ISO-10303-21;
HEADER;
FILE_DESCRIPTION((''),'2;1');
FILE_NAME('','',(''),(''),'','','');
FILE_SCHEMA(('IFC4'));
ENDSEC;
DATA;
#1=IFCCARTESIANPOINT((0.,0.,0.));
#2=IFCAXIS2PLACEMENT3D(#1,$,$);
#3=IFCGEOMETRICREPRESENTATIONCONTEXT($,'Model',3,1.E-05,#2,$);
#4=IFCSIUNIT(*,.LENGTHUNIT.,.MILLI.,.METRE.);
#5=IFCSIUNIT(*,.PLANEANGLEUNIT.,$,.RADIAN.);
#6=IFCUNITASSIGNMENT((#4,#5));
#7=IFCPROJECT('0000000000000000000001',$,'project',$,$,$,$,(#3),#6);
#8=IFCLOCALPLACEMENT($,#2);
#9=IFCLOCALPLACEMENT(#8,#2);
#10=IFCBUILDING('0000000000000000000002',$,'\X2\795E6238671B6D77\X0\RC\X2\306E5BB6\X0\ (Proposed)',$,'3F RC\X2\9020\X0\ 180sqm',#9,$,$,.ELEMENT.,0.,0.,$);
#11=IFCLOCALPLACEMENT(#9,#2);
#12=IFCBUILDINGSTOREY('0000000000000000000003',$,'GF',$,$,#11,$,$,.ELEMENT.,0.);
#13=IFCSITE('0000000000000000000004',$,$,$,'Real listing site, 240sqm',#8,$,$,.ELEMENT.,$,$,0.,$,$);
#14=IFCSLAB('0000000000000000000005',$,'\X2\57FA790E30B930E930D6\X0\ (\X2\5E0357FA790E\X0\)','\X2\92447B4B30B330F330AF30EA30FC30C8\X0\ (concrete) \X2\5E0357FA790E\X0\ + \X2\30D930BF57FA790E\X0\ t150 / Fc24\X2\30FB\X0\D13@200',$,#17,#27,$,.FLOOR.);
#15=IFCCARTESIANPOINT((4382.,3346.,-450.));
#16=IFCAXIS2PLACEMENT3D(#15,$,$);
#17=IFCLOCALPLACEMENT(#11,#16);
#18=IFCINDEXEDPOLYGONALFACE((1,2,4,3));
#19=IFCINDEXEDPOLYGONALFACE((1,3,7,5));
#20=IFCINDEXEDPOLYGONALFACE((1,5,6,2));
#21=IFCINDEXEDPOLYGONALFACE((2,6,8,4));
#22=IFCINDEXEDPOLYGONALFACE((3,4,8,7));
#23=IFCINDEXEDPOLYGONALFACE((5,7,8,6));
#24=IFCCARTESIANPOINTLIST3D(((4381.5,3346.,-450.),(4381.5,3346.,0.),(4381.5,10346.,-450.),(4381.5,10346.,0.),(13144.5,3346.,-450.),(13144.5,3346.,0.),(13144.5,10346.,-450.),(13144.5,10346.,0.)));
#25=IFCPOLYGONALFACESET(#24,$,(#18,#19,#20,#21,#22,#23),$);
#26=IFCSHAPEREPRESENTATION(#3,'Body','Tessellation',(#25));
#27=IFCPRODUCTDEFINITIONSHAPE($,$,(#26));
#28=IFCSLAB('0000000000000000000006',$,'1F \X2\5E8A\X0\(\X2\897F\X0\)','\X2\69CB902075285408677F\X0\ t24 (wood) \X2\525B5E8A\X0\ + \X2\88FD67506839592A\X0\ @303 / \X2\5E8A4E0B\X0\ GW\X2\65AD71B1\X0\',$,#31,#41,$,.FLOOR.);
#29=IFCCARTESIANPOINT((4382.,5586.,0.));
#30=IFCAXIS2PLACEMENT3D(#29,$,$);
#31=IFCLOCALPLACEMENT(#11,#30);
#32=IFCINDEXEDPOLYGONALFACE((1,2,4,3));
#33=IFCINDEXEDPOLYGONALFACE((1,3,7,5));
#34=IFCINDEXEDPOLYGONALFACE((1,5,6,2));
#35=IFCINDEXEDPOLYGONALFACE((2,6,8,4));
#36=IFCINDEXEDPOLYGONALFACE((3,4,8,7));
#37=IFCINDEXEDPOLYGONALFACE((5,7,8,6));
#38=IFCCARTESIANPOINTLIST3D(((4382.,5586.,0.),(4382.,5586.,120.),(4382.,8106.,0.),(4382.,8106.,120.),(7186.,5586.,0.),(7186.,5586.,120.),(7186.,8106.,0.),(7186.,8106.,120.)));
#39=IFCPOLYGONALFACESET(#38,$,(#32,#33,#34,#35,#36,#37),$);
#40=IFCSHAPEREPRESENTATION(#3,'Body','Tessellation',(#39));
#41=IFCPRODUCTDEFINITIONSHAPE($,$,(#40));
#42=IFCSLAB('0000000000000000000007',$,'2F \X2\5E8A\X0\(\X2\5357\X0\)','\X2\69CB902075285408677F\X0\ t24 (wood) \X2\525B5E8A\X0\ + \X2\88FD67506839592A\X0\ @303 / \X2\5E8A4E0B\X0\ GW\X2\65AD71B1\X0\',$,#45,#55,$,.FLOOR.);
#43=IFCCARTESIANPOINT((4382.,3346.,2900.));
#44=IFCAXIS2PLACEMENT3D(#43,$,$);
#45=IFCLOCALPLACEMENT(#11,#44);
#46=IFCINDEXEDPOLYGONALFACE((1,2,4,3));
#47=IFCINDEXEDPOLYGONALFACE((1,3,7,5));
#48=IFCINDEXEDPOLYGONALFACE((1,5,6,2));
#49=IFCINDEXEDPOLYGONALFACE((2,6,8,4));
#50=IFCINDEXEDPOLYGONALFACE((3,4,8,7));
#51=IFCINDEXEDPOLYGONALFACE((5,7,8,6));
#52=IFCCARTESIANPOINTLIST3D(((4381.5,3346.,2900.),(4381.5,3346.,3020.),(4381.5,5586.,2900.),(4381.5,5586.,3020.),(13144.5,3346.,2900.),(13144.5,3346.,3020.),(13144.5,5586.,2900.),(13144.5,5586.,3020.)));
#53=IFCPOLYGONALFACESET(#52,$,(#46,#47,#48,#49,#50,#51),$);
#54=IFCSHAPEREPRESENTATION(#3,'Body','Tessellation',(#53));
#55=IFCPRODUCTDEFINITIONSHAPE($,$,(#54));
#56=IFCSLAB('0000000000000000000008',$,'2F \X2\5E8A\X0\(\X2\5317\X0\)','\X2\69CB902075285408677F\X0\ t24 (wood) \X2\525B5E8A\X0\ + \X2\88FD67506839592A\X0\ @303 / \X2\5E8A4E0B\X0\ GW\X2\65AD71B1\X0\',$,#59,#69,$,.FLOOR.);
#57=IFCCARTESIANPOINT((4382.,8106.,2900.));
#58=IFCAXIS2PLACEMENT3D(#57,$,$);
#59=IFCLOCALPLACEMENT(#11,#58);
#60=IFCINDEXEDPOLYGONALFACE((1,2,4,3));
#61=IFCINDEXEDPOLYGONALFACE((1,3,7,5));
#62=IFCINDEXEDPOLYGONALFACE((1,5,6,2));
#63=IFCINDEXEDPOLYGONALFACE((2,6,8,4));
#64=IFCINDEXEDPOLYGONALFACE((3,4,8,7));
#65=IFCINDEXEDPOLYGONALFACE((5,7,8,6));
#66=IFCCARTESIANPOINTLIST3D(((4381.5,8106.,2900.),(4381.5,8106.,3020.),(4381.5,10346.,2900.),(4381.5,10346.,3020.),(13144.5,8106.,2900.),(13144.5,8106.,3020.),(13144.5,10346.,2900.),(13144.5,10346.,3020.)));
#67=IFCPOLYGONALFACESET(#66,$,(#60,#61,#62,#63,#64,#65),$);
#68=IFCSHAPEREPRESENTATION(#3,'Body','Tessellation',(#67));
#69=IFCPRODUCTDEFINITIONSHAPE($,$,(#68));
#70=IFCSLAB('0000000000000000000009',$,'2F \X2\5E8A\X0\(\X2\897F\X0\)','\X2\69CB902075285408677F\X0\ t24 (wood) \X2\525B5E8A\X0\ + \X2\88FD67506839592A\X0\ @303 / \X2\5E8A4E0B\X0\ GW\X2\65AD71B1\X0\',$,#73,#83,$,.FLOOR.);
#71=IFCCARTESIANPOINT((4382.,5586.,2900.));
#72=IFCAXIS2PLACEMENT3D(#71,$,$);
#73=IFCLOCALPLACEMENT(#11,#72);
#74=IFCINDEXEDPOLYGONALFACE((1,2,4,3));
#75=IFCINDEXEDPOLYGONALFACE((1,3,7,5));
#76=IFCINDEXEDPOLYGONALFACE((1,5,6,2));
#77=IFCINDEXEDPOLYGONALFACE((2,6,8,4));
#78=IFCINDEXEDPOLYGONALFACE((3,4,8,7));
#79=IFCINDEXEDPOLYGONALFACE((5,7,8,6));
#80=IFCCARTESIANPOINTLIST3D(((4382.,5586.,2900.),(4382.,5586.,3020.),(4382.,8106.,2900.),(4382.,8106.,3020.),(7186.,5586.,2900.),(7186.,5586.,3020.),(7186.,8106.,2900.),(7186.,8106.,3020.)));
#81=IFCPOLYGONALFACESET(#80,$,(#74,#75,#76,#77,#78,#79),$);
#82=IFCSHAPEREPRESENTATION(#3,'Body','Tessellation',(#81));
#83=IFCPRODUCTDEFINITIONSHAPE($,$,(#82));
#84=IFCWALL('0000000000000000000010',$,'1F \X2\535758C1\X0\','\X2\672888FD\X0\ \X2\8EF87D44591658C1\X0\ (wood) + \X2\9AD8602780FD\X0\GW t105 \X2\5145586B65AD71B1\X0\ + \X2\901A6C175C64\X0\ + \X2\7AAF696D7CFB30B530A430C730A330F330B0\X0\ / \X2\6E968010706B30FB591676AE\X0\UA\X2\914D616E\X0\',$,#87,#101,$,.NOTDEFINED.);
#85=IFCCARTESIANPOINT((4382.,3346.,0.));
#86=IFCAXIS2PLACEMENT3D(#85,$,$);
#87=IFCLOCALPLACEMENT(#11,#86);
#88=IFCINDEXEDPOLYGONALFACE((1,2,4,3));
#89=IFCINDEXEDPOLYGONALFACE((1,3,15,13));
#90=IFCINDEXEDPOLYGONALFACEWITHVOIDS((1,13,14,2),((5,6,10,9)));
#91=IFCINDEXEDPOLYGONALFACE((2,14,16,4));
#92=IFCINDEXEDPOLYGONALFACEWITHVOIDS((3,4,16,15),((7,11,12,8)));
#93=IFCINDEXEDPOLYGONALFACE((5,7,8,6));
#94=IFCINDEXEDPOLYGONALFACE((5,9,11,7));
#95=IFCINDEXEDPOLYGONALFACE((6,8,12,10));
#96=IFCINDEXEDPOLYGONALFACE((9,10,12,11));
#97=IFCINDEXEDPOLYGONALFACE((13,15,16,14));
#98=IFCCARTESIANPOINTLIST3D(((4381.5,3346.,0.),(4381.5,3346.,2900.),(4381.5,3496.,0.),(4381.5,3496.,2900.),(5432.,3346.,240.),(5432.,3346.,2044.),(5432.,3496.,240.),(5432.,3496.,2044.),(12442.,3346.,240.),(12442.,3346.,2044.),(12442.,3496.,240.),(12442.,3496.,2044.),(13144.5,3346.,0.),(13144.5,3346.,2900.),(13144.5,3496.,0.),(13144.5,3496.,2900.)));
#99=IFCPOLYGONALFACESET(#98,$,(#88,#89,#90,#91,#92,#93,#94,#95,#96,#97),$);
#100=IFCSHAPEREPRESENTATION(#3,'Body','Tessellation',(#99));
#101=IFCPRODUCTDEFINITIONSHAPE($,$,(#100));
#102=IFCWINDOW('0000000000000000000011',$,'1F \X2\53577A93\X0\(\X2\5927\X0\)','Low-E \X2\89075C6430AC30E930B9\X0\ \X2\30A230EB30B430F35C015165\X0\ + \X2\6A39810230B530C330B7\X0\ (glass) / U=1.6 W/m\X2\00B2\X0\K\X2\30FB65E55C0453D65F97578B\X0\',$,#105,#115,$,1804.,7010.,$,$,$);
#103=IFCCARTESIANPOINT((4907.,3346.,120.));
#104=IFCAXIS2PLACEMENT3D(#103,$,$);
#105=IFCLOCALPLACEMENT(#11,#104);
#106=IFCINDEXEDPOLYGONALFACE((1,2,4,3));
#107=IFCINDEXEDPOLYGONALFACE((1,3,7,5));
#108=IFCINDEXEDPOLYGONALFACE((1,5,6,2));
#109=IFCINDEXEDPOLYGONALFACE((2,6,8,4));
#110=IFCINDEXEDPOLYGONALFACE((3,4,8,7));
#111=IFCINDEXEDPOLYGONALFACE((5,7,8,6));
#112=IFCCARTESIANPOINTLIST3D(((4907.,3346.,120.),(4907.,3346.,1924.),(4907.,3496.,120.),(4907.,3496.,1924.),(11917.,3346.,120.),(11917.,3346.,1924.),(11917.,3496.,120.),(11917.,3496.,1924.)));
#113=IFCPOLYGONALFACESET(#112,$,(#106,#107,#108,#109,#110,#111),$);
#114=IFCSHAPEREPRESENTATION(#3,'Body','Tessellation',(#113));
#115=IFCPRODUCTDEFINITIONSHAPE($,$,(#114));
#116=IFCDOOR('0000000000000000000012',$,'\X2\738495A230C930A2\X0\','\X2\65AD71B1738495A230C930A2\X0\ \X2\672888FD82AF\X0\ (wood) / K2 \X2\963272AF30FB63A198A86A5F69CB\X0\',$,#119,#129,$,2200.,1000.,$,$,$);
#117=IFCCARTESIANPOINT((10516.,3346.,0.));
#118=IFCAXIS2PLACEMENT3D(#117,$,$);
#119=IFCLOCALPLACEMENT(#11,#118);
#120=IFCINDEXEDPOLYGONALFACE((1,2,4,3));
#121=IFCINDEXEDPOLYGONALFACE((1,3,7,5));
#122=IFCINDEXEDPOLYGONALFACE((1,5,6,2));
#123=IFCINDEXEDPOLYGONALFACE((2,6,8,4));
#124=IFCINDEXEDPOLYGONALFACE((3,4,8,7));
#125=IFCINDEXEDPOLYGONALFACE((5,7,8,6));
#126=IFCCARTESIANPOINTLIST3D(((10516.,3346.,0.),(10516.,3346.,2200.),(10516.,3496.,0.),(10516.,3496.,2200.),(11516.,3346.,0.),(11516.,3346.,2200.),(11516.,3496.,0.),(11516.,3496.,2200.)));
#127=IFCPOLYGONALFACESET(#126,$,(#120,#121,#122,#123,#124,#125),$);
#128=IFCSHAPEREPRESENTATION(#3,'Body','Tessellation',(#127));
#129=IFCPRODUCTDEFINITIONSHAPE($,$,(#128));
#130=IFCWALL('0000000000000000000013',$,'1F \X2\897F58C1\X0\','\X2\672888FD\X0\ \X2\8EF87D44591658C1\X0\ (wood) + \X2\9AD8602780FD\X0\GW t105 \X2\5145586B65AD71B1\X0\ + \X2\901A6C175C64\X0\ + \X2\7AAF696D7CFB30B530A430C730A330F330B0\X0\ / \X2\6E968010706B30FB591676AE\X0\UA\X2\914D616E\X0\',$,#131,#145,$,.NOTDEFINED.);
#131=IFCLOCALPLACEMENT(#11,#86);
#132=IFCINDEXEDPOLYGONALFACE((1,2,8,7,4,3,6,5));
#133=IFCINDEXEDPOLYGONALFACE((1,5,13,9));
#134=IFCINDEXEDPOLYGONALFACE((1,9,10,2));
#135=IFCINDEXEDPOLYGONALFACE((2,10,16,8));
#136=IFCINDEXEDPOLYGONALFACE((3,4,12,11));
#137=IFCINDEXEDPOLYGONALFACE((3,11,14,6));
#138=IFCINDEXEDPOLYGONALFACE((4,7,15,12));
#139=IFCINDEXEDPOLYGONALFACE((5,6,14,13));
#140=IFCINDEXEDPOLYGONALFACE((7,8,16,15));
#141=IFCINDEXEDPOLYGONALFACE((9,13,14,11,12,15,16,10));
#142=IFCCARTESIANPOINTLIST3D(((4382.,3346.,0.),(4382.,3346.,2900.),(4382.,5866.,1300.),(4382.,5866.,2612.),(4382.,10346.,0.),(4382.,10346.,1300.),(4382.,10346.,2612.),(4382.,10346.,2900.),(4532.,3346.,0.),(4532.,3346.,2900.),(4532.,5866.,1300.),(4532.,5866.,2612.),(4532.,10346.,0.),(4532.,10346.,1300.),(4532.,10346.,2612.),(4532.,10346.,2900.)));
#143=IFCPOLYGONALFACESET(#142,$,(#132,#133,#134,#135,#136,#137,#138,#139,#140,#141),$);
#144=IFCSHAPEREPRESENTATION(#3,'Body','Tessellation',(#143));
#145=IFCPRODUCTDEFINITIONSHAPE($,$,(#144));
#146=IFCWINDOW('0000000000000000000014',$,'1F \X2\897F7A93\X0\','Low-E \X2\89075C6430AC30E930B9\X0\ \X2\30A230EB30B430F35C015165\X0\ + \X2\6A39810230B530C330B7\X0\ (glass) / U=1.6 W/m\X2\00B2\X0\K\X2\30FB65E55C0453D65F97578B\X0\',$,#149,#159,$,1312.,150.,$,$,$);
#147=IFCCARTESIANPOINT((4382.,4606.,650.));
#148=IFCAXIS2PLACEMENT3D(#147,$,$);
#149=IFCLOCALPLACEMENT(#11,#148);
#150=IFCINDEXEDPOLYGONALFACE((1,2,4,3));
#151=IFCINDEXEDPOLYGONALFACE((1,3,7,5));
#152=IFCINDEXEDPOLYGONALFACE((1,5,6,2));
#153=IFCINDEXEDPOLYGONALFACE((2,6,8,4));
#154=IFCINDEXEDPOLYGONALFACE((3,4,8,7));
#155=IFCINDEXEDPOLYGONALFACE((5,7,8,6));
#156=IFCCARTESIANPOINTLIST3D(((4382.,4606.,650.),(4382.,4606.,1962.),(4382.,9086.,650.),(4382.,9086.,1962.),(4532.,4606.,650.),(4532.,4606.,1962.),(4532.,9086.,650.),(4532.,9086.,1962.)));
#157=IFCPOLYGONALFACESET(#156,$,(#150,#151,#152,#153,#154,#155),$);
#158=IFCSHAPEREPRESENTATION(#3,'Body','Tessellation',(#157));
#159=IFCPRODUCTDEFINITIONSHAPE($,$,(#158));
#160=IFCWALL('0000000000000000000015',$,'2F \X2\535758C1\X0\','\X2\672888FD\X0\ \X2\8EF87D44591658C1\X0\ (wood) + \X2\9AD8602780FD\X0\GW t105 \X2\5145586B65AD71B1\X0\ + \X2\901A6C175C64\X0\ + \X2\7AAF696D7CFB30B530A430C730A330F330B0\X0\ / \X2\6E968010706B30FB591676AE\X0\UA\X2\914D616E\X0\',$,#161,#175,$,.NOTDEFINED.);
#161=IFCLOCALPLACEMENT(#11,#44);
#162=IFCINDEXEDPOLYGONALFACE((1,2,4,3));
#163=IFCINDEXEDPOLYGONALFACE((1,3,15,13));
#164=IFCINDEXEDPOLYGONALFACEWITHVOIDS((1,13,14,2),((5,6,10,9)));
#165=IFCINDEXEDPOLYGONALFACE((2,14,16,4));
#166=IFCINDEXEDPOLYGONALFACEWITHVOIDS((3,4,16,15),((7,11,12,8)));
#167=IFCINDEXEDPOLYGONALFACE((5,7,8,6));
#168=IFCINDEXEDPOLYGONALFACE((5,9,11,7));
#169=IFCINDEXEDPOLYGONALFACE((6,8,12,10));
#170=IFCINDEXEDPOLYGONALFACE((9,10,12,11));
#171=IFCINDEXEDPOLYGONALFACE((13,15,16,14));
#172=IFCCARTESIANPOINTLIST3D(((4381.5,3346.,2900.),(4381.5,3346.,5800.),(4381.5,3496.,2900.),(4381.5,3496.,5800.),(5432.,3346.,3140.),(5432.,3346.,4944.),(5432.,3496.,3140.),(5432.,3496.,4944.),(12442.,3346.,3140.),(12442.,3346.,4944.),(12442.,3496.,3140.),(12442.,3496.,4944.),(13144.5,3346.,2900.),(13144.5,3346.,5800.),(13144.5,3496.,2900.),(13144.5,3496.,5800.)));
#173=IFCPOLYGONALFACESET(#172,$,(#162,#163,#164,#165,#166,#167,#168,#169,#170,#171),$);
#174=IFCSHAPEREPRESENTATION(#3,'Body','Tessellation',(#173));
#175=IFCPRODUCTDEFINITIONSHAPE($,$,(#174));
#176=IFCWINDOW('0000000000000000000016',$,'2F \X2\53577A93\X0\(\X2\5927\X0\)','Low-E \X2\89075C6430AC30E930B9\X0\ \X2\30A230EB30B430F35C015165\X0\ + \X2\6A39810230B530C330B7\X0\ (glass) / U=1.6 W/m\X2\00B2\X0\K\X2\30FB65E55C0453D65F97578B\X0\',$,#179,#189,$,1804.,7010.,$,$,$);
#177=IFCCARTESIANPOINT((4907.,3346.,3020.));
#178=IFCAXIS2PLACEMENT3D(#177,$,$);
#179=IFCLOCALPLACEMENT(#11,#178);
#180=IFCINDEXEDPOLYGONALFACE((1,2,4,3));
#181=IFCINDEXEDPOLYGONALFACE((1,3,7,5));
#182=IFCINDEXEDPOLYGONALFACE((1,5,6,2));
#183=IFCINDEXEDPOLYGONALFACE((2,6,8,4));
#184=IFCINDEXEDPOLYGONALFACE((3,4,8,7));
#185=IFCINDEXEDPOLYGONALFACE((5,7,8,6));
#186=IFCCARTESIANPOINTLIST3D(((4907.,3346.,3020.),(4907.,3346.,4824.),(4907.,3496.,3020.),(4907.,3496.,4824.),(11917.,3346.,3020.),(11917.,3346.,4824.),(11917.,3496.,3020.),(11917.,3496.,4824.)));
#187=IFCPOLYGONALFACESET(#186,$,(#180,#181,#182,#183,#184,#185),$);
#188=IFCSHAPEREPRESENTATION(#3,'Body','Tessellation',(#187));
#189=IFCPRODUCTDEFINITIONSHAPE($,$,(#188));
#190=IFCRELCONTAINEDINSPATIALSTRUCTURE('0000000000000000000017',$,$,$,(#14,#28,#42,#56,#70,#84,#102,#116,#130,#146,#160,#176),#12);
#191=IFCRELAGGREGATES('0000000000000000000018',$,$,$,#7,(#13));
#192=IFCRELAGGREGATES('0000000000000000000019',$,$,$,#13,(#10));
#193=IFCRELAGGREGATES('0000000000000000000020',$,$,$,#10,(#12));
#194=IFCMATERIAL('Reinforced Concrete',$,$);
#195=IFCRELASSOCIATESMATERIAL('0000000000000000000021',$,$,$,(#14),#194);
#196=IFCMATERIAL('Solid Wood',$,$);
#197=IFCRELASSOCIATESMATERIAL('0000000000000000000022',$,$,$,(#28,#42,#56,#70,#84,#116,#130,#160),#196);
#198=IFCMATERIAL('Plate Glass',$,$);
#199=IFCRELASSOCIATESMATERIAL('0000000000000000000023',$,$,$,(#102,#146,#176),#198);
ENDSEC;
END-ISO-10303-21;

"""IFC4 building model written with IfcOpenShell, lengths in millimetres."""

from ifc_helpers import new_model, si_unit, frame, frame_2d, origin, place, context, project, spatial, rectangle, extrude, material, element, fill, save


model = new_model("IFC4")

# Units and contexts
model_context = context("Model", 3, precision=1e-05, world=origin())
ifc_project = project(units=[si_unit("LENGTHUNIT", "METRE", prefix="MILLI"), si_unit("PLANEANGLEUNIT", "RADIAN")], contexts=[model_context])

# Site, building, storey
site_placement = place(None, origin())
site = spatial("IfcSite", under=ifc_project, at=site_placement, ObjectType="Real listing site, 240sqm", CompositionType="ELEMENT", RefElevation=0.0)
building_placement = place(site_placement, origin())
building = spatial("IfcBuilding", under=site, at=building_placement, Name="神戸望海RCの家 (Proposed)", ObjectType="3F RC造 180sqm", CompositionType="ELEMENT", ElevationOfRefHeight=0.0, ElevationOfTerrain=0.0)
storey_placement = place(building_placement, origin())
storey = spatial("IfcBuildingStorey", under=building, at=storey_placement, Name="GF", CompositionType="ELEMENT", Elevation=0.0)

# Slabs
ifc_material_1 = material(Name="Reinforced Concrete")
slab_1_placement = place(storey_placement, frame((4382.0, 3346.0, -450.0)))
element("IfcSlab", 1, at=slab_1_placement, inside=storey, material=ifc_material_1, Name="基礎スラブ (布基礎)", Description="鉄筋コンクリート (concrete) 布基礎 + ベタ基礎 t150 / Fc24・D13@200", PredefinedType="FLOOR", context=model_context, shape_type="SweptSolid", body=[
    extrude(rectangle(XDim=8763.0, YDim=7000.0, at=frame_2d((4381.0, 3500.0))), frame((4382.0, 3346.0, -450.0)), (0.0, 0.0, 1.0), 450.0),
])
ifc_material_2 = material(Name="Solid Wood")
slab_2_placement = place(storey_placement, frame((4382.0, 5586.0, 0.0)))
element("IfcSlab", 2, at=slab_2_placement, inside=storey, material=ifc_material_2, Name="1F 床(西)", Description="構造用合板 t24 (wood) 剛床 + 製材根太 @303 / 床下 GW断熱", PredefinedType="FLOOR", context=model_context, shape_type="SweptSolid", body=[
    extrude(rectangle(XDim=2804.0, YDim=2520.0, at=frame_2d((1402.0, 1260.0))), frame((4382.0, 5586.0, 0.0)), (0.0, 0.0, 1.0), 120.0),
])
slab_3_placement = place(storey_placement, frame((4382.0, 3346.0, 2900.0)))
element("IfcSlab", 3, at=slab_3_placement, inside=storey, material=ifc_material_2, Name="2F 床(南)", Description="構造用合板 t24 (wood) 剛床 + 製材根太 @303 / 床下 GW断熱", PredefinedType="FLOOR", context=model_context, shape_type="SweptSolid", body=[
    extrude(rectangle(XDim=8763.0, YDim=2240.0, at=frame_2d((4381.0, 1120.0))), frame((4382.0, 3346.0, 2900.0)), (0.0, 0.0, 1.0), 120.0),
])
slab_4_placement = place(storey_placement, frame((4382.0, 8106.0, 2900.0)))
element("IfcSlab", 4, at=slab_4_placement, inside=storey, material=ifc_material_2, Name="2F 床(北)", Description="構造用合板 t24 (wood) 剛床 + 製材根太 @303 / 床下 GW断熱", PredefinedType="FLOOR", context=model_context, shape_type="SweptSolid", body=[
    extrude(rectangle(XDim=8763.0, YDim=2240.0, at=frame_2d((4381.0, 1120.0))), frame((4382.0, 8106.0, 2900.0)), (0.0, 0.0, 1.0), 120.0),
])
slab_5_placement = place(storey_placement, frame((4382.0, 5586.0, 2900.0)))
element("IfcSlab", 5, at=slab_5_placement, inside=storey, material=ifc_material_2, Name="2F 床(西)", Description="構造用合板 t24 (wood) 剛床 + 製材根太 @303 / 床下 GW断熱", PredefinedType="FLOOR", context=model_context, shape_type="SweptSolid", body=[
    extrude(rectangle(XDim=2804.0, YDim=2520.0, at=frame_2d((1402.0, 1260.0))), frame((4382.0, 5586.0, 2900.0)), (0.0, 0.0, 1.0), 120.0),
])

# Wall, openings, window, door
wall_1_placement = place(storey_placement, frame((4382.0, 3346.0, 0.0)))
wall_1 = element("IfcWall", 6, at=wall_1_placement, inside=storey, material=ifc_material_2, Name="1F 南壁", Description="木製 軸組外壁 (wood) + 高性能GW t105 充填断熱 + 通気層 + 窯業系サイディング / 準耐火・外皮UA配慮", PredefinedType="NOTDEFINED", context=model_context, shape_type="SweptSolid", body=[
    extrude(rectangle(XDim=8763.0, YDim=150.0, at=frame_2d((4381.0, 75.0))), frame((4382.0, 3346.0, 0.0)), (0.0, 0.0, 1.0), 2900.0),
])
opening_1_placement = place(storey_placement, frame((4907.0, 3346.0, 120.0)))
opening_1 = element("IfcOpeningElement", 7, at=opening_1_placement, cuts=wall_1, PredefinedType="NOTDEFINED", context=model_context, shape_type="SweptSolid", body=[
    extrude(rectangle(XDim=7010.0, YDim=150.0, at=frame_2d((3505.0, 75.0))), frame((4907.0, 3346.0, 120.0)), (0.0, 0.0, 1.0), 1804.0),
])
opening_2_placement = place(storey_placement, frame((10516.0, 3346.0, 0.0)))
opening_2 = element("IfcOpeningElement", 8, at=opening_2_placement, cuts=wall_1, PredefinedType="NOTDEFINED", context=model_context, shape_type="SweptSolid", body=[
    extrude(rectangle(XDim=1000.0, YDim=150.0, at=frame_2d((500.0, 75.0))), frame((10516.0, 3346.0, 0.0)), (0.0, 0.0, 1.0), 2200.0),
])
ifc_material_3 = material(Name="Plate Glass")
window_1_placement = place(storey_placement, frame((4907.0, 3346.0, 120.0)))
window_1 = element("IfcWindow", 9, at=window_1_placement, inside=storey, material=ifc_material_3, Name="1F 南窓(大)", Description="Low-E 複層ガラス アルゴン封入 + 樹脂サッシ (glass) / U=1.6 W/m²K・日射取得型", OverallHeight=1804.0, OverallWidth=7010.0, context=model_context, shape_type="SweptSolid", body=[
    extrude(rectangle(XDim=7010.0, YDim=150.0, at=frame_2d((3505.0, 75.0))), frame((4907.0, 3346.0, 120.0)), (0.0, 0.0, 1.0), 1804.0),
])
fill(opening_1, window_1)
door_placement = place(storey_placement, frame((10516.0, 3346.0, 0.0)))
door = element("IfcDoor", 10, at=door_placement, inside=storey, material=ifc_material_2, Name="玄関ドア", Description="断熱玄関ドア 木製芯 (wood) / K2 防犯・採風機構", OverallHeight=2200.0, OverallWidth=1000.0, context=model_context, shape_type="SweptSolid", body=[
    extrude(rectangle(XDim=1000.0, YDim=150.0, at=frame_2d((500.0, 75.0))), frame((10516.0, 3346.0, 0.0)), (0.0, 0.0, 1.0), 2200.0),
])
fill(opening_2, door)

# Walls, openings, windows
wall_2_placement = place(storey_placement, frame((4382.0, 3346.0, 0.0)))
wall_2 = element("IfcWall", 11, at=wall_2_placement, inside=storey, material=ifc_material_2, Name="1F 西壁", Description="木製 軸組外壁 (wood) + 高性能GW t105 充填断熱 + 通気層 + 窯業系サイディング / 準耐火・外皮UA配慮", PredefinedType="NOTDEFINED", context=model_context, shape_type="SweptSolid", body=[
    extrude(rectangle(XDim=150.0, YDim=7000.0, at=frame_2d((75.0, 3500.0))), frame((4382.0, 3346.0, 0.0)), (0.0, 0.0, 1.0), 2900.0),
])
opening_3_placement = place(storey_placement, frame((4382.0, 4606.0, 650.0)))
opening_3 = element("IfcOpeningElement", 12, at=opening_3_placement, cuts=wall_2, PredefinedType="NOTDEFINED", context=model_context, shape_type="SweptSolid", body=[
    extrude(rectangle(XDim=150.0, YDim=4480.0, at=frame_2d((75.0, 2240.0))), frame((4382.0, 4606.0, 650.0)), (0.0, 0.0, 1.0), 1312.0),
])
window_2_placement = place(storey_placement, frame((4382.0, 4606.0, 650.0)))
window_2 = element("IfcWindow", 13, at=window_2_placement, inside=storey, material=ifc_material_3, Name="1F 西窓", Description="Low-E 複層ガラス アルゴン封入 + 樹脂サッシ (glass) / U=1.6 W/m²K・日射取得型", OverallHeight=1312.0, OverallWidth=150.0, context=model_context, shape_type="SweptSolid", body=[
    extrude(rectangle(XDim=150.0, YDim=4480.0, at=frame_2d((75.0, 2240.0))), frame((4382.0, 4606.0, 650.0)), (0.0, 0.0, 1.0), 1312.0),
])
fill(opening_3, window_2)
wall_3_placement = place(storey_placement, frame((4382.0, 3346.0, 2900.0)))
wall_3 = element("IfcWall", 14, at=wall_3_placement, inside=storey, material=ifc_material_2, Name="2F 南壁", Description="木製 軸組外壁 (wood) + 高性能GW t105 充填断熱 + 通気層 + 窯業系サイディング / 準耐火・外皮UA配慮", PredefinedType="NOTDEFINED", context=model_context, shape_type="SweptSolid", body=[
    extrude(rectangle(XDim=8763.0, YDim=150.0, at=frame_2d((4381.0, 75.0))), frame((4382.0, 3346.0, 2900.0)), (0.0, 0.0, 1.0), 2900.0),
])
opening_4_placement = place(storey_placement, frame((4907.0, 3346.0, 3020.0)))
opening_4 = element("IfcOpeningElement", 15, at=opening_4_placement, cuts=wall_3, PredefinedType="NOTDEFINED", context=model_context, shape_type="SweptSolid", body=[
    extrude(rectangle(XDim=7010.0, YDim=150.0, at=frame_2d((3505.0, 75.0))), frame((4907.0, 3346.0, 3020.0)), (0.0, 0.0, 1.0), 1804.0),
])
window_3_placement = place(storey_placement, frame((4907.0, 3346.0, 3020.0)))
window_3 = element("IfcWindow", 16, at=window_3_placement, inside=storey, material=ifc_material_3, Name="2F 南窓(大)", Description="Low-E 複層ガラス アルゴン封入 + 樹脂サッシ (glass) / U=1.6 W/m²K・日射取得型", OverallHeight=1804.0, OverallWidth=7010.0, context=model_context, shape_type="SweptSolid", body=[
    extrude(rectangle(XDim=7010.0, YDim=150.0, at=frame_2d((3505.0, 75.0))), frame((4907.0, 3346.0, 3020.0)), (0.0, 0.0, 1.0), 1804.0),
])
fill(opening_4, window_3)

save(model, "model.ifc")
